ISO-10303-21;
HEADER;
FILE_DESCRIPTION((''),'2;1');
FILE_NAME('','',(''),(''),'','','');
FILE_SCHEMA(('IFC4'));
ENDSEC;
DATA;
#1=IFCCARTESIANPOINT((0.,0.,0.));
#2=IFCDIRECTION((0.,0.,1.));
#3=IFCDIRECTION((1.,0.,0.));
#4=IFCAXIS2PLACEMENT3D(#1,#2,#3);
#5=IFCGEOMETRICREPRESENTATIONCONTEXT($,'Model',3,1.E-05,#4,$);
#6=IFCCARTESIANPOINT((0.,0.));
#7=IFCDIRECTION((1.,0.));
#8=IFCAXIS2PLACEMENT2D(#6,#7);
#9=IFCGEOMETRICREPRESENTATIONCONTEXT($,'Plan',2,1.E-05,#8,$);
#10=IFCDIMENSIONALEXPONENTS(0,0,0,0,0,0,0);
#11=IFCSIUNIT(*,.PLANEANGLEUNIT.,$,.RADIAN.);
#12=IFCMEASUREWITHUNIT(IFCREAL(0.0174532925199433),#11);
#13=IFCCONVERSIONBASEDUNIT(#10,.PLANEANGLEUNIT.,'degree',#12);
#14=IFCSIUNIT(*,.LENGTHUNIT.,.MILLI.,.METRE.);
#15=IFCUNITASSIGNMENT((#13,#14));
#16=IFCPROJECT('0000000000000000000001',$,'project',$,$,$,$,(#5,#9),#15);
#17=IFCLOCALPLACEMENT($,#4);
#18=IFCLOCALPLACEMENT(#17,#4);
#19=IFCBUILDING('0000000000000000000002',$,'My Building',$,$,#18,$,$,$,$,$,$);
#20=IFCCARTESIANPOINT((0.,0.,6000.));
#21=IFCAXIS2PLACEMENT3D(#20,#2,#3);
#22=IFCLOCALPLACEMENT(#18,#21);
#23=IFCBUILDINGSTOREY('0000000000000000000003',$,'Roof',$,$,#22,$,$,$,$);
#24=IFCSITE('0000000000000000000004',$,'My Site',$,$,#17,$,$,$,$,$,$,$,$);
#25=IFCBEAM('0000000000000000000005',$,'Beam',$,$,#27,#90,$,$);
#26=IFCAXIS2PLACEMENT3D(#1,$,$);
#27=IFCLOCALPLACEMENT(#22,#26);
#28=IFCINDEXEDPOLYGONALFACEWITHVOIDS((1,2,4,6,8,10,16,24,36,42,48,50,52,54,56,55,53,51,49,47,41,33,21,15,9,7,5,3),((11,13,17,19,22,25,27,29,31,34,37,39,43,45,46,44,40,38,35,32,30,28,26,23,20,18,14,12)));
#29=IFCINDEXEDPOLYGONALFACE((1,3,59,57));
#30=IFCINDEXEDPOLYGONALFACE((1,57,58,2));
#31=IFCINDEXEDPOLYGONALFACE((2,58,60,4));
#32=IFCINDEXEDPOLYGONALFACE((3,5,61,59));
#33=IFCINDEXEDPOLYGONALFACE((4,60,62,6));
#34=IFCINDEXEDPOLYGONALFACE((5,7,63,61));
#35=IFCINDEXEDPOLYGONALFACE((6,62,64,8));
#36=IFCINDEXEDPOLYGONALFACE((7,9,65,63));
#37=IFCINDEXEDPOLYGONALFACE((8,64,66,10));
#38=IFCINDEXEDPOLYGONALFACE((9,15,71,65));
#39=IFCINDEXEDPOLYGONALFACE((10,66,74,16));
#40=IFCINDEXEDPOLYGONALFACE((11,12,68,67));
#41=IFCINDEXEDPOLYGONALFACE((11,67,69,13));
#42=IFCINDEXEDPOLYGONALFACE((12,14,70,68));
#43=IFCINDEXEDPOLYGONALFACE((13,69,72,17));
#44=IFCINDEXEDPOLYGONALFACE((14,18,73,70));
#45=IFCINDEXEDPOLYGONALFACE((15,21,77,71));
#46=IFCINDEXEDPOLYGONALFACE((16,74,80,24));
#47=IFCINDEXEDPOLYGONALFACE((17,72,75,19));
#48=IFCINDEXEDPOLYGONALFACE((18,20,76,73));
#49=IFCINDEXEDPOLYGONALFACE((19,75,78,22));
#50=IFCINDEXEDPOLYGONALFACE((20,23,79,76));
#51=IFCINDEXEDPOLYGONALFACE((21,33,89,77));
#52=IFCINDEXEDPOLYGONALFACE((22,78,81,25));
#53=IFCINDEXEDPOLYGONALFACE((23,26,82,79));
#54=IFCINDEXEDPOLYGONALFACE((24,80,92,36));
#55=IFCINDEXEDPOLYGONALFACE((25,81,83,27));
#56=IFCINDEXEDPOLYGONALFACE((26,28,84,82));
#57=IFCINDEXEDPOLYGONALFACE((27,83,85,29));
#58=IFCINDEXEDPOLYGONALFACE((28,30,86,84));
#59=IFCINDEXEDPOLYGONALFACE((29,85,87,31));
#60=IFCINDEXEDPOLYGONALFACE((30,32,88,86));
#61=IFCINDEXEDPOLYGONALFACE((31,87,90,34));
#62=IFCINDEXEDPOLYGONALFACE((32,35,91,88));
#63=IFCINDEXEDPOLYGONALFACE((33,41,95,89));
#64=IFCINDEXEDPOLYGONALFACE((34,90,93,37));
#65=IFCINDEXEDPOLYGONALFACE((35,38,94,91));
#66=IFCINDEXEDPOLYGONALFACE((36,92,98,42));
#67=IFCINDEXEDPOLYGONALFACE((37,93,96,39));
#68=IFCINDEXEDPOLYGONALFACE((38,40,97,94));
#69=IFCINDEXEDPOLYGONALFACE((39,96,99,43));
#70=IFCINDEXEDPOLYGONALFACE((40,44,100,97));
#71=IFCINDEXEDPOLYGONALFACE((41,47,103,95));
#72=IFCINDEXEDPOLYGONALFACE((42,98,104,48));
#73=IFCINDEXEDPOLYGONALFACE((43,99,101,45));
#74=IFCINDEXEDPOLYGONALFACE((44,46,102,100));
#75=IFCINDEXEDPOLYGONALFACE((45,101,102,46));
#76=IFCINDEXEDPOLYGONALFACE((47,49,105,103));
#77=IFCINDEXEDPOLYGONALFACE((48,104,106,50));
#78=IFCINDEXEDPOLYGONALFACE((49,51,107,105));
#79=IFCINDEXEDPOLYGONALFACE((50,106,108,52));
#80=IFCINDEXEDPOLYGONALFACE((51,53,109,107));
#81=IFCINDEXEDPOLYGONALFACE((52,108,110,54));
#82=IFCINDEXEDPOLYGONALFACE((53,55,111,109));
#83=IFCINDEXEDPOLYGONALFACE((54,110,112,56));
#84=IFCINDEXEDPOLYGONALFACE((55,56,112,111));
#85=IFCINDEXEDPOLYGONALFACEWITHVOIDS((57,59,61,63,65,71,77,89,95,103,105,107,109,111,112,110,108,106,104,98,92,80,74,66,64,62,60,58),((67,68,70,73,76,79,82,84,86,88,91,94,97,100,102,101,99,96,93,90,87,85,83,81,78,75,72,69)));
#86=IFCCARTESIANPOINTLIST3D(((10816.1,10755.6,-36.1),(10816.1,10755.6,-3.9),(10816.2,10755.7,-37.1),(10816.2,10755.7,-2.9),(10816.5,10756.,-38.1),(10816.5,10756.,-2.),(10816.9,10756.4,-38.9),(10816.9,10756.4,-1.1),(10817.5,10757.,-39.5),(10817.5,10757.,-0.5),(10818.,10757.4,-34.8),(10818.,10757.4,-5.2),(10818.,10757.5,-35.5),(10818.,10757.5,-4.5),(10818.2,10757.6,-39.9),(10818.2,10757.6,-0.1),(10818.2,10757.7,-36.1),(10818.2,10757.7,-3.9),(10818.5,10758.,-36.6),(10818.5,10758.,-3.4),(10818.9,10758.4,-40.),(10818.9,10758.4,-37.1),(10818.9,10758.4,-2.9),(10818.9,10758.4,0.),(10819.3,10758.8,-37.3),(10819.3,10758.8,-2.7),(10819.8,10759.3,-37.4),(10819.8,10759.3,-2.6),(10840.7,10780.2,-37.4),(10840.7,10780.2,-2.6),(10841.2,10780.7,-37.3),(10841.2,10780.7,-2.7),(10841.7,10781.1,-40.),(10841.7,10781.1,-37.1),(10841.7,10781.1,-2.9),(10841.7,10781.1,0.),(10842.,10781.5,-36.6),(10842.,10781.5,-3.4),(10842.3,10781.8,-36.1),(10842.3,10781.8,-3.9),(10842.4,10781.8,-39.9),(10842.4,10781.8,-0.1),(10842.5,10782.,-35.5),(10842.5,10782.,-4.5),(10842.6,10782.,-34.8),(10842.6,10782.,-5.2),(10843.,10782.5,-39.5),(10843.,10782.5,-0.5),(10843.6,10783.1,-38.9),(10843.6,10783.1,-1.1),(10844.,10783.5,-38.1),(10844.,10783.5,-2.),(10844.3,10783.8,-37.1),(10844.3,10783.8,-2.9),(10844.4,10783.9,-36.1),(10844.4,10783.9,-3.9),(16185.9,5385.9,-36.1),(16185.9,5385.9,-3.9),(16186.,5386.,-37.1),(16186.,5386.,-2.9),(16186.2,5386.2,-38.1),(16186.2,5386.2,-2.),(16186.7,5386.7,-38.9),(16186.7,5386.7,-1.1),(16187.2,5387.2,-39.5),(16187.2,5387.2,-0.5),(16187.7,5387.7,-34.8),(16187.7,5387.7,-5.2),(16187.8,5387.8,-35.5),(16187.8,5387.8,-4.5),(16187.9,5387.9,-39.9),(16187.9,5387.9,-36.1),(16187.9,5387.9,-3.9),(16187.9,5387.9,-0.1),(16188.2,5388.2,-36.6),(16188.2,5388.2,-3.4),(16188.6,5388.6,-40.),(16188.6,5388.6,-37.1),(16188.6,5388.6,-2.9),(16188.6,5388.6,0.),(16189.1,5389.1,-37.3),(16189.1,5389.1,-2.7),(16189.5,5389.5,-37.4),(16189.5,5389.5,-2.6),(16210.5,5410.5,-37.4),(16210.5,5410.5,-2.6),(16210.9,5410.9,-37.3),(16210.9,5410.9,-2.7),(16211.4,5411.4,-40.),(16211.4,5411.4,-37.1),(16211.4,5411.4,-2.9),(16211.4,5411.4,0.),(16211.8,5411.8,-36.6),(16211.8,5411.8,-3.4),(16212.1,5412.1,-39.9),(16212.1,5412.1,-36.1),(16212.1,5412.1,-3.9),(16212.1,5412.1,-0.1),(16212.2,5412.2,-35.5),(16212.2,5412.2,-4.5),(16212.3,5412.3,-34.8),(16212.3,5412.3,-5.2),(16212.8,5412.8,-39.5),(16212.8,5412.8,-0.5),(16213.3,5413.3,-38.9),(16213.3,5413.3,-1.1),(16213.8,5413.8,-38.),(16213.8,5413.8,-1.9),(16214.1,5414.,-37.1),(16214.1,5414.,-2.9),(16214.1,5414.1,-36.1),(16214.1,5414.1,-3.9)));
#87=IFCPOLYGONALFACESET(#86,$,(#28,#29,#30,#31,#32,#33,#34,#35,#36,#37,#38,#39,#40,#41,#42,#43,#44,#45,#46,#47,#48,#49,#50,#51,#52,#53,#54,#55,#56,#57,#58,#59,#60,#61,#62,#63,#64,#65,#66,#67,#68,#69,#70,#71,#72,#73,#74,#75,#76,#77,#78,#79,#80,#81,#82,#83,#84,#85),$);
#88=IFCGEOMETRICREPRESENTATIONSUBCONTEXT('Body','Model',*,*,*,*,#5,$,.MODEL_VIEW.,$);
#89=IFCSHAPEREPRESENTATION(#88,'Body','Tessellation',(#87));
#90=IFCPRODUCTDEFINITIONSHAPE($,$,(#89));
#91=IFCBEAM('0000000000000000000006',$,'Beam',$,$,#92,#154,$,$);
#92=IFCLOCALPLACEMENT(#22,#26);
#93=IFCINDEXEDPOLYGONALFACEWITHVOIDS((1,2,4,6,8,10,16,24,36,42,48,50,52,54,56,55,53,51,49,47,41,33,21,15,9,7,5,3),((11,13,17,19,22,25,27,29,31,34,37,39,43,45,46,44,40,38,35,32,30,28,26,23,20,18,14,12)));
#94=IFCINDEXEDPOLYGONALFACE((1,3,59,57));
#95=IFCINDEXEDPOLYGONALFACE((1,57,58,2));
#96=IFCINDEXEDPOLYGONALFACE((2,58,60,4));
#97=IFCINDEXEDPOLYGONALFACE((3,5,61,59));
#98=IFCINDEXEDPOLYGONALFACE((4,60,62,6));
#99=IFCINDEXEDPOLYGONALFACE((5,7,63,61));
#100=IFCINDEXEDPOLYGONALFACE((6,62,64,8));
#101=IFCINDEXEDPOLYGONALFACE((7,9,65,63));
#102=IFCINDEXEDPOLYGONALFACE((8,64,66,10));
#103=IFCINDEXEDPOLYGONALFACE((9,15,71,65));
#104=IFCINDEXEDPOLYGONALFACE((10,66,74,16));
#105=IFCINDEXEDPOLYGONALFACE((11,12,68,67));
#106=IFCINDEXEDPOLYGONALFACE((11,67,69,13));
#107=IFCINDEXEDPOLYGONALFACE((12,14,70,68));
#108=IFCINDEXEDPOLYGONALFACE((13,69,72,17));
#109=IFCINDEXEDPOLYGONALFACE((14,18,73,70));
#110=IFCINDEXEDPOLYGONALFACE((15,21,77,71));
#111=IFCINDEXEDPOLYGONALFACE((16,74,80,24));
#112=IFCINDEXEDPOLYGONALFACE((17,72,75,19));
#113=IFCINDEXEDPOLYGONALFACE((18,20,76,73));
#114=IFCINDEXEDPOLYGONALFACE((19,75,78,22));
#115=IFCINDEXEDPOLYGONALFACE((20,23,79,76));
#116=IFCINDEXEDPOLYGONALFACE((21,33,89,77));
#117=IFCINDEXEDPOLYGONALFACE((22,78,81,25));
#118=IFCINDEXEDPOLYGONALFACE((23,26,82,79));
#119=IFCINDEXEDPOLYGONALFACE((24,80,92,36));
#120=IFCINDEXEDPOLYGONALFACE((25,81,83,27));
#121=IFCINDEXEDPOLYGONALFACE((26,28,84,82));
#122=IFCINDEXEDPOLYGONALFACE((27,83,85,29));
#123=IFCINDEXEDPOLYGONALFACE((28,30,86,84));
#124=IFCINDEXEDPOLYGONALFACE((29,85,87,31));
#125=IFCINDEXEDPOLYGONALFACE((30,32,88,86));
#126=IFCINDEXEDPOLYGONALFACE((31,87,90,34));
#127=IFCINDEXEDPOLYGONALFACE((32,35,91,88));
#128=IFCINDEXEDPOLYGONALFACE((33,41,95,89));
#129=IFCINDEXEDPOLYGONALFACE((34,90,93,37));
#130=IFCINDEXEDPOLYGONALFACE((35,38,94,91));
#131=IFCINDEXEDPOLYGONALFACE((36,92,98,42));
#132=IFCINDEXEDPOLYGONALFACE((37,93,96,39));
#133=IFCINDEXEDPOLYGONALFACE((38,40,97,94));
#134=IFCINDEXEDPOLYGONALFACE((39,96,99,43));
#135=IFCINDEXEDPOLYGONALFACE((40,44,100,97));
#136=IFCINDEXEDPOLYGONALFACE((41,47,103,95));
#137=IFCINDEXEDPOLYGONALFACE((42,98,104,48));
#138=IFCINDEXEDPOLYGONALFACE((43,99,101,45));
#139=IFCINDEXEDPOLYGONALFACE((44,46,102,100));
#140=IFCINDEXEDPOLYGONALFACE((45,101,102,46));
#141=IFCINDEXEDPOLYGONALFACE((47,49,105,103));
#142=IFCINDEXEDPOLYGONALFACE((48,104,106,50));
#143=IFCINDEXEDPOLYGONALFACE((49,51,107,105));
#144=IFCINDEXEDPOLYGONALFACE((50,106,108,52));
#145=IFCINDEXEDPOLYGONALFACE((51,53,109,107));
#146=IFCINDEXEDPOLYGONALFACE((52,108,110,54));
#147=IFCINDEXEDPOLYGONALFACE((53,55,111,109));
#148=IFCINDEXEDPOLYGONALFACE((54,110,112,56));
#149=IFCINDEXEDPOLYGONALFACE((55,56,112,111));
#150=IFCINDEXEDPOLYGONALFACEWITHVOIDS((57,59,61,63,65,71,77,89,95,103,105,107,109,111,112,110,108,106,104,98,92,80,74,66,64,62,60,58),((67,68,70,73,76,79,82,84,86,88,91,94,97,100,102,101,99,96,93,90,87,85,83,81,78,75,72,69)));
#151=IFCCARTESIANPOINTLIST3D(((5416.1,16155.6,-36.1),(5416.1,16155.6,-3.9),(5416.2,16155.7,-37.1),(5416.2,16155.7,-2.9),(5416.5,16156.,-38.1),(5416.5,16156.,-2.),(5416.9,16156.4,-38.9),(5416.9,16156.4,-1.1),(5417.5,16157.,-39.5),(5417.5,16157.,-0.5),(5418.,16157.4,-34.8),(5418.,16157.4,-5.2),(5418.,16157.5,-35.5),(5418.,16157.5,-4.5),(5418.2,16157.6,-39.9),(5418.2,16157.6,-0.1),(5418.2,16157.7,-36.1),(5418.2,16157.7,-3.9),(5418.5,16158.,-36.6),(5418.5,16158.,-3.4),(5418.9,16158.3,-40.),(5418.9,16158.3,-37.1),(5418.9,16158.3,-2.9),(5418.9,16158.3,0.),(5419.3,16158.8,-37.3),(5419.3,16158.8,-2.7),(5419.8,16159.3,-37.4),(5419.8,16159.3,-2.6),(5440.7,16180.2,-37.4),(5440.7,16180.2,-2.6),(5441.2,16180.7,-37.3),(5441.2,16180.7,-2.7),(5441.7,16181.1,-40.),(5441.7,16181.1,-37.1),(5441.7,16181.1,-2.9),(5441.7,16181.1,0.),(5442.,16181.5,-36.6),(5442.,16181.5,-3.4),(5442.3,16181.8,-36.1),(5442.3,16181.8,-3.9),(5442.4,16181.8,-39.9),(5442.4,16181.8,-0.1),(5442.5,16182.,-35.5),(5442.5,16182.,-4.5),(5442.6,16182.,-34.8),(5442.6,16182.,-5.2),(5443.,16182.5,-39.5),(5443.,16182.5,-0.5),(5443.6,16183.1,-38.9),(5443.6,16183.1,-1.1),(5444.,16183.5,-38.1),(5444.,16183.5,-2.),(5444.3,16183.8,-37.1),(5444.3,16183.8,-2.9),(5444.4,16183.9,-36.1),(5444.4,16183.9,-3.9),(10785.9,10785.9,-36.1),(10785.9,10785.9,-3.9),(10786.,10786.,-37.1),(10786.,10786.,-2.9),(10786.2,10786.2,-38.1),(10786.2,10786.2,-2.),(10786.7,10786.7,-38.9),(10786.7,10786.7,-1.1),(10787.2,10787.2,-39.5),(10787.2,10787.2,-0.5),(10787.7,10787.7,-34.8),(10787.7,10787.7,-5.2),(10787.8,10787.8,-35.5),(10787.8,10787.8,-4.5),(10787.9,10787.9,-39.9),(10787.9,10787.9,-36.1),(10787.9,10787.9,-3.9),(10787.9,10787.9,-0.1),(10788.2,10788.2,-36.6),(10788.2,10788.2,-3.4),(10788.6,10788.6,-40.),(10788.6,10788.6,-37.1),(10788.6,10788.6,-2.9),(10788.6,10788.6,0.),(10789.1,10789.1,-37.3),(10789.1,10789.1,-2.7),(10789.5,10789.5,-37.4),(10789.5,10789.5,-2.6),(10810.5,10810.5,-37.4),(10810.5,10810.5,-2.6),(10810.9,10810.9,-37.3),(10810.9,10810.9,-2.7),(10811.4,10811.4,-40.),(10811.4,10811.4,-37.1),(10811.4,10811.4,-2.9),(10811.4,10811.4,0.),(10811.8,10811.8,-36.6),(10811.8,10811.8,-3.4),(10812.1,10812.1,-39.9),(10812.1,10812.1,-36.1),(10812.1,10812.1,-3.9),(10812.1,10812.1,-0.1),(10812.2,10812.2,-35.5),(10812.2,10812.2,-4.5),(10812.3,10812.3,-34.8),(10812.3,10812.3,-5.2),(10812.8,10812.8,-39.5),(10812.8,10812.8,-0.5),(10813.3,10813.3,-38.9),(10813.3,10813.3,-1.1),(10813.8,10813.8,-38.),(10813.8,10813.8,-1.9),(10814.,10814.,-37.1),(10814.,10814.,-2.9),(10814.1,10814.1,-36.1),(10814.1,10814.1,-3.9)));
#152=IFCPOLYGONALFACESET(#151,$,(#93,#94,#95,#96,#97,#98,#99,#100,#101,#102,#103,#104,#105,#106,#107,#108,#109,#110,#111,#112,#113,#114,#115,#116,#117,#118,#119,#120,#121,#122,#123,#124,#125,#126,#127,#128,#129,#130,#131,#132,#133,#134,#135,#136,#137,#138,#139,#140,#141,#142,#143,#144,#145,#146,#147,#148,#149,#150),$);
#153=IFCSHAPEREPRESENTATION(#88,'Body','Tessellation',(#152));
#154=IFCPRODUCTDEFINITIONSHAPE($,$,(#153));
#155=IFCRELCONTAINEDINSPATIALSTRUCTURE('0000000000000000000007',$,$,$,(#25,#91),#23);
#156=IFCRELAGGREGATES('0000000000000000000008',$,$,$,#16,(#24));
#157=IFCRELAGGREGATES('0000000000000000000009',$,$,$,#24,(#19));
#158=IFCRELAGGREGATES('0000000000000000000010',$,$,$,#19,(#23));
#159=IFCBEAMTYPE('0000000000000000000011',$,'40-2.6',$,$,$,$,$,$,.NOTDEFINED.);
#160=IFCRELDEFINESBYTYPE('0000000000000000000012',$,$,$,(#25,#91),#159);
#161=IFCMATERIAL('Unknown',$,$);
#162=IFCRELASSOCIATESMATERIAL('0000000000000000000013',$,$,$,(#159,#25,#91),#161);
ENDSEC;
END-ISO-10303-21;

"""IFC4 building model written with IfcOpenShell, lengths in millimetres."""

from ifc_helpers import new_model, entity, si_unit, converted_unit, frame, origin_with_axes, origin_2d_with_axis, place, context, subcontext, project, spatial, hollow_rectangle, extrude, material, material_profile, profile_set, profile_usage, type_object, element, save


model = new_model("IFC4")

# Units and contexts
model_context = context("Model", 3, precision=1e-05, world=origin_with_axes())
plan_context = context("Plan", 2, precision=1e-05, world=origin_2d_with_axis())
body_context = subcontext(model_context, "Body", "Model", "MODEL_VIEW")
ifc_project = project(units=[converted_unit("PLANEANGLEUNIT", "degree", entity("IfcReal", 0.0174532925199433), si_unit("PLANEANGLEUNIT", "RADIAN"), dimensions=[0, 0, 0, 0, 0, 0, 0]), si_unit("LENGTHUNIT", "METRE", prefix="MILLI")], contexts=[model_context, plan_context])

# Site, building, storey
site_placement = place(None, origin_with_axes())
site = spatial("IfcSite", under=ifc_project, at=site_placement, Name="My Site")
building_placement = place(site_placement, origin_with_axes())
building = spatial("IfcBuilding", under=site, at=building_placement, Name="My Building")
storey_placement = place(building_placement, frame((0.0, 0.0, 6000.0), z_axis=(0.0, 0.0, 1.0), x_axis=(1.0, 0.0, 0.0)))
storey = spatial("IfcBuildingStorey", under=building, at=storey_placement, Name="Roof")

# Beams
ifc_material = material(Name="Unknown")
ifc_material_profile_1 = material_profile(ifc_material, hollow_rectangle(XDim=40.0, YDim=40.0, WallThickness=2.6, InnerFilletRadius=2.6, OuterFilletRadius=3.9))
ifc_profile_set_1 = profile_set([ifc_material_profile_1])
beam_type_1 = type_object("IfcBeamType", Name="40-2.6", PredefinedType="NOTDEFINED", material=ifc_profile_set_1)
ifc_profile_usage_1 = profile_usage(ifc_profile_set_1, cardinal=8)
beam_1_placement = place(storey_placement, frame((16200.0, 5400.0, 0.0), z_axis=(-0.707107, 0.707107, 0.0), x_axis=(-0.707107, -0.707107, 0.0)))
element("IfcBeam", 1, at=beam_1_placement, inside=storey, type_object=beam_type_1, material=ifc_profile_usage_1, Name="Beam", context=body_context, shape_type="SweptSolid", body=[
    extrude(hollow_rectangle(XDim=40.0, YDim=40.0, WallThickness=2.6, InnerFilletRadius=2.6, OuterFilletRadius=3.9), frame((0.0, -20.0, 0.0), z_axis=(0.0, 0.0, 1.0), x_axis=(1.0, 0.0, 0.0)), (0.0, 0.0, 1.0), 7594.0),
])
ifc_profile_usage_2 = profile_usage(ifc_profile_set_1, cardinal=8)
beam_2_placement = place(storey_placement, frame((10800.0, 10800.0, 0.0), z_axis=(-0.707107, 0.707107, 0.0), x_axis=(-0.707107, -0.707107, 0.0)))
element("IfcBeam", 2, at=beam_2_placement, inside=storey, type_object=beam_type_1, material=ifc_profile_usage_2, Name="Beam", context=body_context, shape_type="SweptSolid", body=[
    extrude(hollow_rectangle(XDim=40.0, YDim=40.0, WallThickness=2.6, InnerFilletRadius=2.6, OuterFilletRadius=3.9), frame((0.0, -20.0, 0.0), z_axis=(0.0, 0.0, 1.0), x_axis=(1.0, 0.0, 0.0)), (0.0, 0.0, 1.0), 7594.0),
])

save(model, "model.ifc")
